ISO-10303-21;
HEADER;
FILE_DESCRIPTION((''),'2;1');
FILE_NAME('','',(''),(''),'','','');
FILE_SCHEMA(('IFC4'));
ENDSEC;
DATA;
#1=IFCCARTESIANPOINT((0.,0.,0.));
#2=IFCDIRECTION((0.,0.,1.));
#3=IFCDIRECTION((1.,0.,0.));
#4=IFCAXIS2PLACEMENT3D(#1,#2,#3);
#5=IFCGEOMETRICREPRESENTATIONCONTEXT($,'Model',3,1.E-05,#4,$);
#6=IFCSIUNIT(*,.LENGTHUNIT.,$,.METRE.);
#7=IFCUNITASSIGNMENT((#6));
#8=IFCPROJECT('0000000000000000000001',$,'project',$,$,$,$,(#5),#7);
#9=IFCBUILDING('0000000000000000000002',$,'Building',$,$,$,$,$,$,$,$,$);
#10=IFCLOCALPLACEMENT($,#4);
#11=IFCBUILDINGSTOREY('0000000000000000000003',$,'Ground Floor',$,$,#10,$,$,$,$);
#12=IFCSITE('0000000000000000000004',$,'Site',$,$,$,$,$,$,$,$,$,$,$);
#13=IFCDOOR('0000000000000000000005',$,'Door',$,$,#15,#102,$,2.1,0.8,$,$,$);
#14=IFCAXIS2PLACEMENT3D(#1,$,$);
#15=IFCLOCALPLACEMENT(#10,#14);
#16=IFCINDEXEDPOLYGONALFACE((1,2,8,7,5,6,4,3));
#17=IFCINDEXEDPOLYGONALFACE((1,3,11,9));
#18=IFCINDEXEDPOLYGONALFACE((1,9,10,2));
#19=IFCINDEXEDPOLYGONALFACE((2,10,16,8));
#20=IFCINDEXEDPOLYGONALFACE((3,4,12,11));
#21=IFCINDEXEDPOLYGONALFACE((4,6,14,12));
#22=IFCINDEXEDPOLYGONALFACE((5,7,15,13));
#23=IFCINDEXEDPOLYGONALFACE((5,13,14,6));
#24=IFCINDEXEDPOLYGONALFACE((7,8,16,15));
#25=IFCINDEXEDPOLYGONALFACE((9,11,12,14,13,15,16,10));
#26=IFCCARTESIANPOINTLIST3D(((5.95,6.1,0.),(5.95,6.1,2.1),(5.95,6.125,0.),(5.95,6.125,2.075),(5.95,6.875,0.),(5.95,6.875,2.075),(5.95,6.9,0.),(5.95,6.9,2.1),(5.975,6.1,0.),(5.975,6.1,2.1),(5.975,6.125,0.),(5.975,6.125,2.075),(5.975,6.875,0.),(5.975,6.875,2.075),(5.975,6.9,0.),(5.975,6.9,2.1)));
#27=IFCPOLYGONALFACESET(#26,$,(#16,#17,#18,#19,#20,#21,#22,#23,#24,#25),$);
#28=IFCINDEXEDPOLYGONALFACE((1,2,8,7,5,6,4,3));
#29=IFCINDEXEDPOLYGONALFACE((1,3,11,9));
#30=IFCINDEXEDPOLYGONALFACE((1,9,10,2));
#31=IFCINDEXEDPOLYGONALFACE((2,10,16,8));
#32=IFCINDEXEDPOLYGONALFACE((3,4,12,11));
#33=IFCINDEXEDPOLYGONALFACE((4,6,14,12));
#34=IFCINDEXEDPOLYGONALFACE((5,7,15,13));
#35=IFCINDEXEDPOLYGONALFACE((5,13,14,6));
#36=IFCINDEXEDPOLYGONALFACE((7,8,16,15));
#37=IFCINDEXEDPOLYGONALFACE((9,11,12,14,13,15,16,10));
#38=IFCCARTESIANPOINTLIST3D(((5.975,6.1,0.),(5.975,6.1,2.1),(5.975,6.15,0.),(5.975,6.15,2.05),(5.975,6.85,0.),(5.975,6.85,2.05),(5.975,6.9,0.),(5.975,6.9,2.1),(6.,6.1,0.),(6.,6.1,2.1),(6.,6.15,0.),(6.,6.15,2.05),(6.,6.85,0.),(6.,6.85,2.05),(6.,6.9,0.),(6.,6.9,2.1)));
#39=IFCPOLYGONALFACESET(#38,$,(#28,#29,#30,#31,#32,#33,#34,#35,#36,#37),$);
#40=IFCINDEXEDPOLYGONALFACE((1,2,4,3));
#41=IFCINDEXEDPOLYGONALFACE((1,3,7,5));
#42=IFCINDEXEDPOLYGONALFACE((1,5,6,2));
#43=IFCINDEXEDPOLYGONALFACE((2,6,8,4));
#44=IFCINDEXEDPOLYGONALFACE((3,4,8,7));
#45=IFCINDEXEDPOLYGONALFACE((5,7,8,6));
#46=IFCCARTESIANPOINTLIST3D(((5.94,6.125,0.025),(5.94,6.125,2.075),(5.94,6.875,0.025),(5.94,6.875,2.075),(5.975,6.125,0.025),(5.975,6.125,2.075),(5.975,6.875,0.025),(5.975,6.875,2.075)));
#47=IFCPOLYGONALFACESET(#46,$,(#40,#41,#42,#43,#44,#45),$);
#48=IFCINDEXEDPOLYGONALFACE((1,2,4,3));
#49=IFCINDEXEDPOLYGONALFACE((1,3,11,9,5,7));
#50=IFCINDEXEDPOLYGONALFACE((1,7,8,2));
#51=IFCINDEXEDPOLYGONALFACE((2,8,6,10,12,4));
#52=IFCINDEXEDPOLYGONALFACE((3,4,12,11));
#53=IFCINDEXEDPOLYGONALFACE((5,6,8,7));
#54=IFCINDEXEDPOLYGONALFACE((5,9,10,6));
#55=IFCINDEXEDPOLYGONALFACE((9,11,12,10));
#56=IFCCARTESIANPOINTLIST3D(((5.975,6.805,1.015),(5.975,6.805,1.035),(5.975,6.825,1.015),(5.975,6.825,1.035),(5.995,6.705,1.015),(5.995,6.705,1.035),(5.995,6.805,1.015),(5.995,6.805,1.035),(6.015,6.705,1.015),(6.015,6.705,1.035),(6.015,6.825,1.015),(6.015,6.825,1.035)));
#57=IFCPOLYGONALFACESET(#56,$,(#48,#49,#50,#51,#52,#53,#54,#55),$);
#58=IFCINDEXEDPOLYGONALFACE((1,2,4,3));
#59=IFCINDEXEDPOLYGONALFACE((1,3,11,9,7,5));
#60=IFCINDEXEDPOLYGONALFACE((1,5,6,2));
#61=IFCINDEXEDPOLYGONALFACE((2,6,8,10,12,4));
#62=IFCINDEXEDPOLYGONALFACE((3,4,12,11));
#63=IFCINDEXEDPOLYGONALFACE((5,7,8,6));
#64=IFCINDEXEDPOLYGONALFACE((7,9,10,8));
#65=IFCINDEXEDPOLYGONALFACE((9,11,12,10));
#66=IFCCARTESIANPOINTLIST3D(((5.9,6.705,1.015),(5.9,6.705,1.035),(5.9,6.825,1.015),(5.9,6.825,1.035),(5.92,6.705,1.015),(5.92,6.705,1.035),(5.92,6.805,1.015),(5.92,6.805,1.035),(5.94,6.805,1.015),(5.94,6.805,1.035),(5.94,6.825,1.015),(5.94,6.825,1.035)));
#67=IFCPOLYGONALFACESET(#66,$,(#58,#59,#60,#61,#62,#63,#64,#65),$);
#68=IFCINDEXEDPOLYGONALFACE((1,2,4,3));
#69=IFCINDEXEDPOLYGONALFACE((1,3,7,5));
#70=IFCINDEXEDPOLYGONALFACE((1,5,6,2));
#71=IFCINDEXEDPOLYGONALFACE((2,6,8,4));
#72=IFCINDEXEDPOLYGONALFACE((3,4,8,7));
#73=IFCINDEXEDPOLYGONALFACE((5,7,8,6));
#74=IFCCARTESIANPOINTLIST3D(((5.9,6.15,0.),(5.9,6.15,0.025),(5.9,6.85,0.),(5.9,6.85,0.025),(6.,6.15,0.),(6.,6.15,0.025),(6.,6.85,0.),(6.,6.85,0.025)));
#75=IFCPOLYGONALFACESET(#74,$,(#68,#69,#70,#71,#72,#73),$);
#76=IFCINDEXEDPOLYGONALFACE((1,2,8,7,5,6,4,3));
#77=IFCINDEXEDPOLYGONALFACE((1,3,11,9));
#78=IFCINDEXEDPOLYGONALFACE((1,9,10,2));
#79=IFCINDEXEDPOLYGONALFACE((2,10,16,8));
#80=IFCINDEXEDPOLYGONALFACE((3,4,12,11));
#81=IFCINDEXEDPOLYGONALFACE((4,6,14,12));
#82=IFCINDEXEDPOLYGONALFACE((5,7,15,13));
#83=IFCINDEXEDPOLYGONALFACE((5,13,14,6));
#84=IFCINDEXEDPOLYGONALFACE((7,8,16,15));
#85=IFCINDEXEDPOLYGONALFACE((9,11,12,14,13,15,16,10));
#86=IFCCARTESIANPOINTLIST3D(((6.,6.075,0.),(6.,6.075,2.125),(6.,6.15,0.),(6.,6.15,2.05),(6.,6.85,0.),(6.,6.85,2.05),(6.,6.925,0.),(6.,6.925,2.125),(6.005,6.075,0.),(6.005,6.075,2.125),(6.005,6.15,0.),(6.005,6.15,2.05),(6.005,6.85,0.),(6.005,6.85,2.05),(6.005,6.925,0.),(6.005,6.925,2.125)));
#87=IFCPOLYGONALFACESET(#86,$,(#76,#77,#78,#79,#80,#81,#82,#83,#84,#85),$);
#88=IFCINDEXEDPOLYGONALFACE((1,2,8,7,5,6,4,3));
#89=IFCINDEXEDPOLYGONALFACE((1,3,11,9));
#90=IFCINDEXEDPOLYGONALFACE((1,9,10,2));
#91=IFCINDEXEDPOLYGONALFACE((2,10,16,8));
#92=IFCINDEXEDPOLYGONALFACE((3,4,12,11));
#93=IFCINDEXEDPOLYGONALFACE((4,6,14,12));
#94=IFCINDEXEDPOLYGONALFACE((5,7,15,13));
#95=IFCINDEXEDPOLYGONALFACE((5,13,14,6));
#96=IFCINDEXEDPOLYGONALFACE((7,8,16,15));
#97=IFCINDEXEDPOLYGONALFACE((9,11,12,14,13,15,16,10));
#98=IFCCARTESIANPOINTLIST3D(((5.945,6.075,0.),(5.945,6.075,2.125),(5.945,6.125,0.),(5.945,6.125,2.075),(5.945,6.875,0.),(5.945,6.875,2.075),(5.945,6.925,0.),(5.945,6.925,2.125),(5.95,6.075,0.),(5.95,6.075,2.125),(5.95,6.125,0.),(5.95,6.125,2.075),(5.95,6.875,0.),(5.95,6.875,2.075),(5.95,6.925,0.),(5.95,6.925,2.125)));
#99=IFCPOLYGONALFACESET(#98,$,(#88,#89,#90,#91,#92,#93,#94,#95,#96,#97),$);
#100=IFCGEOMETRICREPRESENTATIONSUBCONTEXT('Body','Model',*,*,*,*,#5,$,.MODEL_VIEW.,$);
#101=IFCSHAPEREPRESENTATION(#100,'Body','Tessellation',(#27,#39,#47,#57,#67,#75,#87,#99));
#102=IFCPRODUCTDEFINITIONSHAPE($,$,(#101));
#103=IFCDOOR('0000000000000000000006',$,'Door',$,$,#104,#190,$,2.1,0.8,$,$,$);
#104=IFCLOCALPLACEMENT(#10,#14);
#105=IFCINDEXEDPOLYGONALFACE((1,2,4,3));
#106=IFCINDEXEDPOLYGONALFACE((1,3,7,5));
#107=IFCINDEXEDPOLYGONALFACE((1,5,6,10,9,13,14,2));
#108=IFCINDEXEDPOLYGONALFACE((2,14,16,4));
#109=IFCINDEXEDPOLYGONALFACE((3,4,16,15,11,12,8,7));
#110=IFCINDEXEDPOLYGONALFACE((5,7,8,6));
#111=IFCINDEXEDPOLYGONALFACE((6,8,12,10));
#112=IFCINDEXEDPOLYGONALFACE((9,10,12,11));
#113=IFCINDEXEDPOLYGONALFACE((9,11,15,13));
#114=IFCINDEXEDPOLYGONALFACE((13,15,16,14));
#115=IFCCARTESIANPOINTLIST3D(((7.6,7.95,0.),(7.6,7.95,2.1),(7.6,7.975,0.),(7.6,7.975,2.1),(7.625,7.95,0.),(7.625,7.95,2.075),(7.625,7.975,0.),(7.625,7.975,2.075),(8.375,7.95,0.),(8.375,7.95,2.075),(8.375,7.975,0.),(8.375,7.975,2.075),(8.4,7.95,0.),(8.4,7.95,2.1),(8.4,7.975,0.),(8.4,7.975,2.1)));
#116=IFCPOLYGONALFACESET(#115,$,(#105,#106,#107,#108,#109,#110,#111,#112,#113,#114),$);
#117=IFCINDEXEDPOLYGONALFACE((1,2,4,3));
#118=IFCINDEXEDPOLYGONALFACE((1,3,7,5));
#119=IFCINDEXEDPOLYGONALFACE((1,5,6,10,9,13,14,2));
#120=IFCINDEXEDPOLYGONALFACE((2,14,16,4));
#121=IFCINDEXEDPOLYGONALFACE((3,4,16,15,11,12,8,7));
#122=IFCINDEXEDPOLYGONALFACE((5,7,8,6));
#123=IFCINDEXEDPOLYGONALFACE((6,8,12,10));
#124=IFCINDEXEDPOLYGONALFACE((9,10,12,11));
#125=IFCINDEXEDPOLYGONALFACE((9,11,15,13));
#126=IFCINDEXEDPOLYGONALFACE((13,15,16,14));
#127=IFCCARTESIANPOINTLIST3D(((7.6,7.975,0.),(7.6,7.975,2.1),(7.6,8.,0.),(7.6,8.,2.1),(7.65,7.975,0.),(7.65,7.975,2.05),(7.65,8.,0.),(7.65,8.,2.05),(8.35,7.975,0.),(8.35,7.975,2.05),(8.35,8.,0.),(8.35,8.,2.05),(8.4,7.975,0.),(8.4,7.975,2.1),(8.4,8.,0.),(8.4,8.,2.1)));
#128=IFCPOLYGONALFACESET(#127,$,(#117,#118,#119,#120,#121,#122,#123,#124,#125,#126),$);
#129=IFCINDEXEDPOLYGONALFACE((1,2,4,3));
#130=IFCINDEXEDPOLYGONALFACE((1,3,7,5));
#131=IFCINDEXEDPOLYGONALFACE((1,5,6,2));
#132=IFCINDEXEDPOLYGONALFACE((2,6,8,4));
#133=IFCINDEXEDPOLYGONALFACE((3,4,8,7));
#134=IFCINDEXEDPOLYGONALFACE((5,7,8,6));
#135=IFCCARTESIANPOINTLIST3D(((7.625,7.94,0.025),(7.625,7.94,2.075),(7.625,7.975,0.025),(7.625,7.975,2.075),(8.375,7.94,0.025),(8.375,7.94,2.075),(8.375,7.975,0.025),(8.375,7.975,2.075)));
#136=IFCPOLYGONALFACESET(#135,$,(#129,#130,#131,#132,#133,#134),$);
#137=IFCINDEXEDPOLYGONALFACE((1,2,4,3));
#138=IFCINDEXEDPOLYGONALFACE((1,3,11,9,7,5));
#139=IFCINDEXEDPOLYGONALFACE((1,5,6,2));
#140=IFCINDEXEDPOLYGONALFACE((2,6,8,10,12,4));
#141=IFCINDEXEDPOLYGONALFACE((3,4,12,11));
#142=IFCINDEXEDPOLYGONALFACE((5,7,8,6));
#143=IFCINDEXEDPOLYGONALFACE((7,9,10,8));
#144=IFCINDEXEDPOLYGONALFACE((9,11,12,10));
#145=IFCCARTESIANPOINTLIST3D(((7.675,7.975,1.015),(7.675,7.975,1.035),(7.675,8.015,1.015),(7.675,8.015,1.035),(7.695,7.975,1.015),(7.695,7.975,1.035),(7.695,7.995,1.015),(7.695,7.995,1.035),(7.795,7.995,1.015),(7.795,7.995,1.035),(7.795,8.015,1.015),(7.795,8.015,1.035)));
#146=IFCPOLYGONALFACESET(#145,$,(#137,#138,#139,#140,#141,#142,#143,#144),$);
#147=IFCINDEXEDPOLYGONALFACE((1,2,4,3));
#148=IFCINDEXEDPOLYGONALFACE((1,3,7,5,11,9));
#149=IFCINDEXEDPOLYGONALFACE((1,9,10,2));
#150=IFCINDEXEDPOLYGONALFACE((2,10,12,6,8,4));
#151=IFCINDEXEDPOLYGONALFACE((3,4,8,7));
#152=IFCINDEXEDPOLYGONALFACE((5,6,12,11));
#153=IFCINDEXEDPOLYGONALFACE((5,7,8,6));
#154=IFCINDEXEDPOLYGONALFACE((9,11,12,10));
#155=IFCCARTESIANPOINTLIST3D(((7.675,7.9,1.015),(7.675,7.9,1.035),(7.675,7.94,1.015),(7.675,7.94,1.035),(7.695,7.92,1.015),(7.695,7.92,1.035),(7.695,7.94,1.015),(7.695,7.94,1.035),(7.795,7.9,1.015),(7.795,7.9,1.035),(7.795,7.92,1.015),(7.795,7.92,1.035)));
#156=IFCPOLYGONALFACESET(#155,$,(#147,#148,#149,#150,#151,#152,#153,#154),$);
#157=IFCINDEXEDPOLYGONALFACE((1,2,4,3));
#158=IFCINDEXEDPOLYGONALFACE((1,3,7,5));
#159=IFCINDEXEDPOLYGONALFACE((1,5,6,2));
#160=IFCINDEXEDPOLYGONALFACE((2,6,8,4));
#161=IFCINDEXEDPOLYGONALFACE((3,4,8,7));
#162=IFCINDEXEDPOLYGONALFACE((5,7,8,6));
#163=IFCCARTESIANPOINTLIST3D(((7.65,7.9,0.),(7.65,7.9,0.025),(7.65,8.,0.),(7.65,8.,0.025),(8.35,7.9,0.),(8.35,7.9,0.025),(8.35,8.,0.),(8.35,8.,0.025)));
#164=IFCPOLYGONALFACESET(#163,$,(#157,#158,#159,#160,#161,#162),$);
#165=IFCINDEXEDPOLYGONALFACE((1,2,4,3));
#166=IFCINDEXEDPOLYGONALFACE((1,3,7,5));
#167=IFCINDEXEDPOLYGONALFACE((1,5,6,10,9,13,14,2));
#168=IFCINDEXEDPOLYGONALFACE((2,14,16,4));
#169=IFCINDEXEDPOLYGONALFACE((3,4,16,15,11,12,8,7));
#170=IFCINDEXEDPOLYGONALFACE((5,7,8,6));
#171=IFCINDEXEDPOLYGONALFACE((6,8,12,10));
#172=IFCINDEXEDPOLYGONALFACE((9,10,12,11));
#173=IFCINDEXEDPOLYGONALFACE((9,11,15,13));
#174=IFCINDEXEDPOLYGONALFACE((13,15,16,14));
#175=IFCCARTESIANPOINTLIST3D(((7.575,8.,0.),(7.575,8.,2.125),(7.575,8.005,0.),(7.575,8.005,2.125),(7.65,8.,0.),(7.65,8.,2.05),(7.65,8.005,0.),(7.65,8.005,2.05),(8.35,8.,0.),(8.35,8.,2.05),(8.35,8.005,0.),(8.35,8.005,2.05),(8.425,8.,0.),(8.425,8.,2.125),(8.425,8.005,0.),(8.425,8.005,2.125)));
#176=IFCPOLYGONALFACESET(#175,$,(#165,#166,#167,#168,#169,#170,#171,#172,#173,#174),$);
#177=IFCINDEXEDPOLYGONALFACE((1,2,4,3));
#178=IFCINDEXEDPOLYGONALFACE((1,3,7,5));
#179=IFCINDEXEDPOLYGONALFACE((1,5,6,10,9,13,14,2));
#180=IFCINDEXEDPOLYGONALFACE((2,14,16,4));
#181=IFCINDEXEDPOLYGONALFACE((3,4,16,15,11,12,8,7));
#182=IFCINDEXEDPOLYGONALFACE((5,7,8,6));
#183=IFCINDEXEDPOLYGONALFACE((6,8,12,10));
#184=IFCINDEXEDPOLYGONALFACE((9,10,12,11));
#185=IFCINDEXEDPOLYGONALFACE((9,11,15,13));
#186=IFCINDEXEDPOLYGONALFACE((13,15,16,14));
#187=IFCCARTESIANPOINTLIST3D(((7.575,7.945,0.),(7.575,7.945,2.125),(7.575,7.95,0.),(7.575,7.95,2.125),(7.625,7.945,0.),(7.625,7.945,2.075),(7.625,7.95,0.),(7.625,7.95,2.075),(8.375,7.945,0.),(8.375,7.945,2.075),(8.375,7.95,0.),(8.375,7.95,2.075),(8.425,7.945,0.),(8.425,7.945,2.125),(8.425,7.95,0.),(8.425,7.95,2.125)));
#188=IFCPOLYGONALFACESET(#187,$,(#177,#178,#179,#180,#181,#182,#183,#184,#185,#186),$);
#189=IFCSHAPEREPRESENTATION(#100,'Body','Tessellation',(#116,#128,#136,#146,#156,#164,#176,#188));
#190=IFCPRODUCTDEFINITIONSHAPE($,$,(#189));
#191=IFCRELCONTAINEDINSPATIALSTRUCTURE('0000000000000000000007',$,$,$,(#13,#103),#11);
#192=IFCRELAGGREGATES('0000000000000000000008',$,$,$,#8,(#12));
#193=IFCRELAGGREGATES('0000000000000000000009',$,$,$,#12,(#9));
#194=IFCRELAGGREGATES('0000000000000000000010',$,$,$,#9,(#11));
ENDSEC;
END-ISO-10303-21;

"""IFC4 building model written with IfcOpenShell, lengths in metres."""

from ifc_helpers import new_model, si_unit, frame, origin_with_axes, place, context, subcontext, project, spatial, line, indexed_curve, outline, extrude, element, save


model = new_model("IFC4")

# Units and contexts
model_context = context("Model", 3, precision=1e-05, world=origin_with_axes())
body_context = subcontext(model_context, "Body", "Model", "MODEL_VIEW")
ifc_project = project(units=[si_unit("LENGTHUNIT", "METRE")], contexts=[model_context])

# Site, building, storey
site = spatial("IfcSite", under=ifc_project, Name="Site")
building = spatial("IfcBuilding", under=site, Name="Building")
storey_placement = place(None, origin_with_axes())
storey = spatial("IfcBuildingStorey", under=building, at=storey_placement, Name="Ground Floor")

# Doors
door_1_placement = place(storey_placement, frame((6.0, 6.1, 0.0), z_axis=(0.0, 0.0, 1.0), x_axis=(0.0, 1.0, 0.0)))
element("IfcDoor", 1, at=door_1_placement, inside=storey, Name="Door", OverallHeight=2.1, OverallWidth=0.8, context=body_context, shape_type="SweptSolid", body=[
    extrude(outline(indexed_curve([(0.0, 0.0), (0.0, 2.1), (0.8, 2.1), (0.8, 0.0), (0.775, 0.0), (0.775, 2.075), (0.025, 2.075), (0.025, 0.0)], segments=[line(1, 2, 3, 4, 5, 6, 7, 8, 1)])), frame((0.0, 0.025, 0.0), z_axis=(0.0, -1.0, 0.0), x_axis=(1.0, 0.0, 0.0)), (0.0, 0.0, -1.0), 0.025),
    extrude(outline(indexed_curve([(0.0, 0.0), (0.0, 2.1), (0.8, 2.1), (0.8, 0.0), (0.75, 0.0), (0.75, 2.05), (0.05, 2.05), (0.05, 0.0)], segments=[line(1, 2, 3, 4, 5, 6, 7, 8, 1)])), frame((0.0, 0.0, 0.0), z_axis=(0.0, -1.0, 0.0), x_axis=(1.0, 0.0, 0.0)), (0.0, 0.0, -1.0), 0.025),
    extrude(outline(indexed_curve([(0.0, 0.0), (0.75, 0.0), (0.75, 0.035), (0.0, 0.035)], segments=[line(1, 2, 3, 4, 1)])), frame((0.025, 0.025, 0.025), z_axis=(0.0, 0.0, 1.0), x_axis=(1.0, 0.0, 0.0)), (0.0, 0.0, 1.0), 2.05),
    extrude(outline(indexed_curve([(0.0, 0.0), (0.0, -0.04), (-0.12, -0.04), (-0.12, -0.02), (-0.02, -0.02), (-0.02, 0.0)], segments=[line(1, 2, 3, 4, 5, 6, 1)])), frame((0.725, 0.025, 1.015), z_axis=(0.0, 0.0, 1.0), x_axis=(1.0, 0.0, 0.0)), (0.0, 0.0, 1.0), 0.02),
    extrude(outline(indexed_curve([(0.0, 0.0), (0.0, 0.04), (-0.12, 0.04), (-0.12, 0.02), (-0.02, 0.02), (-0.02, 0.0)], segments=[line(1, 2, 3, 4, 5, 6, 1)])), frame((0.725, 0.06, 1.015), z_axis=(0.0, 0.0, 1.0), x_axis=(1.0, 0.0, 0.0)), (0.0, 0.0, 1.0), 0.02),
    extrude(outline(indexed_curve([(0.0, 0.0), (0.7, 0.0), (0.7, 0.1), (0.0, 0.1)], segments=[line(1, 2, 3, 4, 1)])), frame((0.05, 0.0, 0.0), z_axis=(0.0, 0.0, 1.0), x_axis=(1.0, 0.0, 0.0)), (0.0, 0.0, 1.0), 0.025),
    extrude(outline(indexed_curve([(0.0, 0.0), (0.0, 2.125), (0.85, 2.125), (0.85, 0.0), (0.775, 0.0), (0.775, 2.05), (0.075, 2.05), (0.075, 0.0)], segments=[line(1, 2, 3, 4, 5, 6, 7, 8, 1)])), frame((-0.025, -0.005, 0.0), z_axis=(0.0, -1.0, 0.0), x_axis=(1.0, 0.0, 0.0)), (0.0, 0.0, -1.0), 0.005),
    extrude(outline(indexed_curve([(0.0, 0.0), (0.0, 2.125), (0.85, 2.125), (0.85, 0.0), (0.8, 0.0), (0.8, 2.075), (0.05, 2.075), (0.05, 0.0)], segments=[line(1, 2, 3, 4, 5, 6, 7, 8, 1)])), frame((-0.025, 0.05, 0.0), z_axis=(0.0, -1.0, 0.0), x_axis=(1.0, 0.0, 0.0)), (0.0, 0.0, -1.0), 0.005),
])
door_2_placement = place(storey_placement, frame((8.4, 8.0, 0.0), z_axis=(0.0, 0.0, 1.0), x_axis=(-1.0, 0.0, 0.0)))
element("IfcDoor", 2, at=door_2_placement, inside=storey, Name="Door", OverallHeight=2.1, OverallWidth=0.8, context=body_context, shape_type="SweptSolid", body=[
    extrude(outline(indexed_curve([(0.0, 0.0), (0.0, 2.1), (0.8, 2.1), (0.8, 0.0), (0.775, 0.0), (0.775, 2.075), (0.025, 2.075), (0.025, 0.0)], segments=[line(1, 2, 3, 4, 5, 6, 7, 8, 1)])), frame((0.0, 0.025, 0.0), z_axis=(0.0, -1.0, 0.0), x_axis=(1.0, 0.0, 0.0)), (0.0, 0.0, -1.0), 0.025),
    extrude(outline(indexed_curve([(0.0, 0.0), (0.0, 2.1), (0.8, 2.1), (0.8, 0.0), (0.75, 0.0), (0.75, 2.05), (0.05, 2.05), (0.05, 0.0)], segments=[line(1, 2, 3, 4, 5, 6, 7, 8, 1)])), frame((0.0, 0.0, 0.0), z_axis=(0.0, -1.0, 0.0), x_axis=(1.0, 0.0, 0.0)), (0.0, 0.0, -1.0), 0.025),
    extrude(outline(indexed_curve([(0.0, 0.0), (0.75, 0.0), (0.75, 0.035), (0.0, 0.035)], segments=[line(1, 2, 3, 4, 1)])), frame((0.025, 0.025, 0.025), z_axis=(0.0, 0.0, 1.0), x_axis=(1.0, 0.0, 0.0)), (0.0, 0.0, 1.0), 2.05),
    extrude(outline(indexed_curve([(0.0, 0.0), (0.0, -0.04), (-0.12, -0.04), (-0.12, -0.02), (-0.02, -0.02), (-0.02, 0.0)], segments=[line(1, 2, 3, 4, 5, 6, 1)])), frame((0.725, 0.025, 1.015), z_axis=(0.0, 0.0, 1.0), x_axis=(1.0, 0.0, 0.0)), (0.0, 0.0, 1.0), 0.02),
    extrude(outline(indexed_curve([(0.0, 0.0), (0.0, 0.04), (-0.12, 0.04), (-0.12, 0.02), (-0.02, 0.02), (-0.02, 0.0)], segments=[line(1, 2, 3, 4, 5, 6, 1)])), frame((0.725, 0.06, 1.015), z_axis=(0.0, 0.0, 1.0), x_axis=(1.0, 0.0, 0.0)), (0.0, 0.0, 1.0), 0.02),
    extrude(outline(indexed_curve([(0.0, 0.0), (0.7, 0.0), (0.7, 0.1), (0.0, 0.1)], segments=[line(1, 2, 3, 4, 1)])), frame((0.05, 0.0, 0.0), z_axis=(0.0, 0.0, 1.0), x_axis=(1.0, 0.0, 0.0)), (0.0, 0.0, 1.0), 0.025),
    extrude(outline(indexed_curve([(0.0, 0.0), (0.0, 2.125), (0.85, 2.125), (0.85, 0.0), (0.775, 0.0), (0.775, 2.05), (0.075, 2.05), (0.075, 0.0)], segments=[line(1, 2, 3, 4, 5, 6, 7, 8, 1)])), frame((-0.025, -0.005, 0.0), z_axis=(0.0, -1.0, 0.0), x_axis=(1.0, 0.0, 0.0)), (0.0, 0.0, -1.0), 0.005),
    extrude(outline(indexed_curve([(0.0, 0.0), (0.0, 2.125), (0.85, 2.125), (0.85, 0.0), (0.8, 0.0), (0.8, 2.075), (0.05, 2.075), (0.05, 0.0)], segments=[line(1, 2, 3, 4, 5, 6, 7, 8, 1)])), frame((-0.025, 0.05, 0.0), z_axis=(0.0, -1.0, 0.0), x_axis=(1.0, 0.0, 0.0)), (0.0, 0.0, -1.0), 0.005),
])

save(model, "model.ifc")
